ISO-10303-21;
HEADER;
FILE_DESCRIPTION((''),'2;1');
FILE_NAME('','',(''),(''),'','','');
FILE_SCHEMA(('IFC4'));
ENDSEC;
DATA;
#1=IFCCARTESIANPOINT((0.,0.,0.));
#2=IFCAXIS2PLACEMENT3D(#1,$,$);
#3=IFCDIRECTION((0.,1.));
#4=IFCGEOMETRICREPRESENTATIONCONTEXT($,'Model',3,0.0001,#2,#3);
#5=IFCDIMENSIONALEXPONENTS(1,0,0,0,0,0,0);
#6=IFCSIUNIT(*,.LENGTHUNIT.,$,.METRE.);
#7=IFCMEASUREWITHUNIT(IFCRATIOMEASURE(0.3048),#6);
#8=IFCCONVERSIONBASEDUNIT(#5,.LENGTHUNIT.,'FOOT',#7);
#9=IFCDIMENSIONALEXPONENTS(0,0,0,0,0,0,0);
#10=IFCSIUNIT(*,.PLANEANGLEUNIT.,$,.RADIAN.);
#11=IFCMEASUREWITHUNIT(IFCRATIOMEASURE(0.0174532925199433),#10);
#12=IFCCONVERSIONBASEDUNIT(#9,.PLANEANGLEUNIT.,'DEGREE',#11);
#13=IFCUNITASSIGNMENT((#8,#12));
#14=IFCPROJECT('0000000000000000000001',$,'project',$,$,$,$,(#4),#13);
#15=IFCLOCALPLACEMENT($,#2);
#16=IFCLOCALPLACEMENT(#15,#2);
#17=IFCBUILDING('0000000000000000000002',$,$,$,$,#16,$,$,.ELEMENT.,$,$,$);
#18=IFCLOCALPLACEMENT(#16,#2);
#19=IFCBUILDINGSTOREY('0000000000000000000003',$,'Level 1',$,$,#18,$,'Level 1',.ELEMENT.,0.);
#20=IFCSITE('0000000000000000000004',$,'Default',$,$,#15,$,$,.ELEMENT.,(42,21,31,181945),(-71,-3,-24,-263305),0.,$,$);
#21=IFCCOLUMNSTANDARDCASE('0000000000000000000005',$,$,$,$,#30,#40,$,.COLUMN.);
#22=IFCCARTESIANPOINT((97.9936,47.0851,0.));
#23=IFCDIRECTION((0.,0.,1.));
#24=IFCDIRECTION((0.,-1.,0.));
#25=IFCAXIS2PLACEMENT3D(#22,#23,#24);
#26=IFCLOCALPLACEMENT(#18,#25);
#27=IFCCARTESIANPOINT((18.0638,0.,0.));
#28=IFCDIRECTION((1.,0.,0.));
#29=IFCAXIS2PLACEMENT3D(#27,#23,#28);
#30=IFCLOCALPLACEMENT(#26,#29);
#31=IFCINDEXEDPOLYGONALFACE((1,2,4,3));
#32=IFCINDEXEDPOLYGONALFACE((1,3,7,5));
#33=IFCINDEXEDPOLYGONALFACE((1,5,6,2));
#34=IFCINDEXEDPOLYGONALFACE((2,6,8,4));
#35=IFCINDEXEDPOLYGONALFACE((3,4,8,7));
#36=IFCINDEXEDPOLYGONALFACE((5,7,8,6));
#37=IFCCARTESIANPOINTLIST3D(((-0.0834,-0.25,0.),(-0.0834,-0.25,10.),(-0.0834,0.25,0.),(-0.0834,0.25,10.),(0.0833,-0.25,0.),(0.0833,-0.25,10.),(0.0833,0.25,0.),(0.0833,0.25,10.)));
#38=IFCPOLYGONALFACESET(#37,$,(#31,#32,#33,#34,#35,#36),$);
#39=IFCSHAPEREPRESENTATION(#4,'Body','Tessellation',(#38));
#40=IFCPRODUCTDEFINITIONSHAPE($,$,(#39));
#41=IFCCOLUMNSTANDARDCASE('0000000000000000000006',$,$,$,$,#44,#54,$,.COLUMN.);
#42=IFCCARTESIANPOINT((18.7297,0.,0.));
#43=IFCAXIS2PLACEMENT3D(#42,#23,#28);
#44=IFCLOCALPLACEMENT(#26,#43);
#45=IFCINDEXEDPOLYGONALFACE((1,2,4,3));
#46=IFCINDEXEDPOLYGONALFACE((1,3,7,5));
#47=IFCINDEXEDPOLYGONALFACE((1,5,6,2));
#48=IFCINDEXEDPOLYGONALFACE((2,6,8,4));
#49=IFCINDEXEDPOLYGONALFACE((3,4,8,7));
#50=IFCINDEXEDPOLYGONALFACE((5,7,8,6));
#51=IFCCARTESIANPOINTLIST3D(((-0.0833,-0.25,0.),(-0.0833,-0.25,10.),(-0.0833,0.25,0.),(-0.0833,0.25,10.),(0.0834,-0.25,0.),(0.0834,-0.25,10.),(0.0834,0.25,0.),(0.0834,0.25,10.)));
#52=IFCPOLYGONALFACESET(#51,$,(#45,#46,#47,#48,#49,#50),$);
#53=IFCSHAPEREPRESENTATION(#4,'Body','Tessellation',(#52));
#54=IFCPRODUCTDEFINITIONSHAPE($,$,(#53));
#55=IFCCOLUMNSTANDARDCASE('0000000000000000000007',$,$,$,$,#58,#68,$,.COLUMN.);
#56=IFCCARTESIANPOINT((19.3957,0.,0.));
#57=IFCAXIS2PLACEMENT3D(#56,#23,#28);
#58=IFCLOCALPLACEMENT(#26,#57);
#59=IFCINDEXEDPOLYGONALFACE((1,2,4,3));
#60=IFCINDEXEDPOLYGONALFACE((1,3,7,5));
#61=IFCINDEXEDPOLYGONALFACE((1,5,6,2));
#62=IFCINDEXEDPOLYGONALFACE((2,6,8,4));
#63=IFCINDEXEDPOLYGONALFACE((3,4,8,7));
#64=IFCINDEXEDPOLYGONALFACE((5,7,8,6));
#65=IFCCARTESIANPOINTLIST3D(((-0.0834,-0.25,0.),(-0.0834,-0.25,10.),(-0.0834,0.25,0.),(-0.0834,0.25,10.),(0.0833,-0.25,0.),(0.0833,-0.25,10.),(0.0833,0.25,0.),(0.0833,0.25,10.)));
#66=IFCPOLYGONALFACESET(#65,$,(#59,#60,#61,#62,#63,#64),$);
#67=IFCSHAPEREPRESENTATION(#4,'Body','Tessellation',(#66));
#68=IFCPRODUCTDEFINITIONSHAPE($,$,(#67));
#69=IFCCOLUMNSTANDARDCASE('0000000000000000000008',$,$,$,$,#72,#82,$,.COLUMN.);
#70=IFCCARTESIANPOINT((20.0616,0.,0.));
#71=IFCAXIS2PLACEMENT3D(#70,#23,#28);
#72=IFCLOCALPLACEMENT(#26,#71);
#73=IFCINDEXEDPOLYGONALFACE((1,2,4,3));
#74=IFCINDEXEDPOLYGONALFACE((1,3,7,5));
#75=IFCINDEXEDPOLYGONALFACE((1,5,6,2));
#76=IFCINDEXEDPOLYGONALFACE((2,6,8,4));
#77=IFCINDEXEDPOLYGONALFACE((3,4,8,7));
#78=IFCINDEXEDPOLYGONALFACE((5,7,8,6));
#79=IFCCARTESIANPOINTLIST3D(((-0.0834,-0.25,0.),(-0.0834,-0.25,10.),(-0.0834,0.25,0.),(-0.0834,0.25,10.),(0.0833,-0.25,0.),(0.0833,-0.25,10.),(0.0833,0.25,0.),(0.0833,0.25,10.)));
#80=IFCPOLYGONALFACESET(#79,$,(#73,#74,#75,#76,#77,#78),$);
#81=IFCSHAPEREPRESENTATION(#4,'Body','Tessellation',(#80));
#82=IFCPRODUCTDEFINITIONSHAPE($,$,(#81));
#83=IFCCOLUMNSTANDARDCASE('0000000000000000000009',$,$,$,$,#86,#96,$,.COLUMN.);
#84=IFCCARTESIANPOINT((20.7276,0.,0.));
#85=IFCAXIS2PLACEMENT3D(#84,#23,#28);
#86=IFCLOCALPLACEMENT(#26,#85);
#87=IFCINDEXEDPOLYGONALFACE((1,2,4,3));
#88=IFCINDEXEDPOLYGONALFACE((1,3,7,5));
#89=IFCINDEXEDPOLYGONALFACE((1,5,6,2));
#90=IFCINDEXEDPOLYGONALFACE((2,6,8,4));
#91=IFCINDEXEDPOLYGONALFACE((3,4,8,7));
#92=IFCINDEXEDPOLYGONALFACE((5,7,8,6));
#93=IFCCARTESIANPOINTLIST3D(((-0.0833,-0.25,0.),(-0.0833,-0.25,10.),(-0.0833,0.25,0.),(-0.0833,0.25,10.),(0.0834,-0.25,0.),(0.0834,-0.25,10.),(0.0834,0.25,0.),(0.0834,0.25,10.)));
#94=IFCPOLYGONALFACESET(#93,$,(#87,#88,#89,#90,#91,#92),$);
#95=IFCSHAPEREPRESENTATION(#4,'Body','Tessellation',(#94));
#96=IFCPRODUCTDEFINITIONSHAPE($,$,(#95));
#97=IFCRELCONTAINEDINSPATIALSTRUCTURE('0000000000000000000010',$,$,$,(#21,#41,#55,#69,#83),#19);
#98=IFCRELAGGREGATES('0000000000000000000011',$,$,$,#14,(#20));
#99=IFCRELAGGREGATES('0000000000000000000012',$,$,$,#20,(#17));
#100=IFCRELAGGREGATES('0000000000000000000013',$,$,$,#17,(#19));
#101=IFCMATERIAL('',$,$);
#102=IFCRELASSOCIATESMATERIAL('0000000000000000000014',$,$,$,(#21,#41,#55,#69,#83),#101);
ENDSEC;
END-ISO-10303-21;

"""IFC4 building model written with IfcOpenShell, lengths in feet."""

from ifc_helpers import new_model, entity, si_unit, converted_unit, direction, frame, origin, place, context, project, spatial, rectangle, extrude, material, element, save


model = new_model("IFC4")

# Units and contexts
model_context = context("Model", 3, precision=0.0001, world=origin(), true_north=direction((0.0, 1.0)))
ifc_project = project(units=[converted_unit("LENGTHUNIT", "FOOT", entity("IfcRatioMeasure", 0.3048), si_unit("LENGTHUNIT", "METRE"), dimensions=[1, 0, 0, 0, 0, 0, 0]), converted_unit("PLANEANGLEUNIT", "DEGREE", entity("IfcRatioMeasure", 0.0174532925199433), si_unit("PLANEANGLEUNIT", "RADIAN"), dimensions=[0, 0, 0, 0, 0, 0, 0])], contexts=[model_context])

# Site, building, storey
site_placement = place(None, origin())
site = spatial("IfcSite", under=ifc_project, at=site_placement, Name="Default", CompositionType="ELEMENT", RefLatitude=(42, 21, 31, 181945), RefLongitude=(-71, -3, -24, -263305), RefElevation=0.0)
building_placement = place(site_placement, origin())
building = spatial("IfcBuilding", under=site, at=building_placement, CompositionType="ELEMENT")
storey_placement = place(building_placement, origin())
storey = spatial("IfcBuildingStorey", under=building, at=storey_placement, Name="Level 1", LongName="Level 1", CompositionType="ELEMENT", Elevation=0.0)

# Columns
ifc_material = material(Name="")
placement = place(storey_placement, frame((97.9936, 47.0851, 0.0), z_axis=(0.0, 0.0, 1.0), x_axis=(0.0, -1.0, 0.0)))
for number, where, z_axis, x_axis in (
    (1, (18.0638, 0.0, 0.0), (0.0, 0.0, 1.0), (1.0, 0.0, 0.0)),
    (2, (18.7297, 0.0, 0.0), (0.0, 0.0, 1.0), (1.0, 0.0, 0.0)),
    (3, (19.3957, 0.0, 0.0), (0.0, 0.0, 1.0), (1.0, 0.0, 0.0)),
    (4, (20.0616, 0.0, 0.0), (0.0, 0.0, 1.0), (1.0, 0.0, 0.0)),
    (5, (20.7276, 0.0, 0.0), (0.0, 0.0, 1.0), (1.0, 0.0, 0.0)),
):
    element("IfcColumnStandardCase", number, at=place(placement, frame(where, z_axis=z_axis, x_axis=x_axis)), inside=storey, material=ifc_material, PredefinedType="COLUMN", context=model_context, shape_type="SweptSolid", body=[
        extrude(rectangle(XDim=0.1667, YDim=0.5), origin(), (0.0, 0.0, 1.0), 10.0),
    ])

save(model, "model.ifc")
